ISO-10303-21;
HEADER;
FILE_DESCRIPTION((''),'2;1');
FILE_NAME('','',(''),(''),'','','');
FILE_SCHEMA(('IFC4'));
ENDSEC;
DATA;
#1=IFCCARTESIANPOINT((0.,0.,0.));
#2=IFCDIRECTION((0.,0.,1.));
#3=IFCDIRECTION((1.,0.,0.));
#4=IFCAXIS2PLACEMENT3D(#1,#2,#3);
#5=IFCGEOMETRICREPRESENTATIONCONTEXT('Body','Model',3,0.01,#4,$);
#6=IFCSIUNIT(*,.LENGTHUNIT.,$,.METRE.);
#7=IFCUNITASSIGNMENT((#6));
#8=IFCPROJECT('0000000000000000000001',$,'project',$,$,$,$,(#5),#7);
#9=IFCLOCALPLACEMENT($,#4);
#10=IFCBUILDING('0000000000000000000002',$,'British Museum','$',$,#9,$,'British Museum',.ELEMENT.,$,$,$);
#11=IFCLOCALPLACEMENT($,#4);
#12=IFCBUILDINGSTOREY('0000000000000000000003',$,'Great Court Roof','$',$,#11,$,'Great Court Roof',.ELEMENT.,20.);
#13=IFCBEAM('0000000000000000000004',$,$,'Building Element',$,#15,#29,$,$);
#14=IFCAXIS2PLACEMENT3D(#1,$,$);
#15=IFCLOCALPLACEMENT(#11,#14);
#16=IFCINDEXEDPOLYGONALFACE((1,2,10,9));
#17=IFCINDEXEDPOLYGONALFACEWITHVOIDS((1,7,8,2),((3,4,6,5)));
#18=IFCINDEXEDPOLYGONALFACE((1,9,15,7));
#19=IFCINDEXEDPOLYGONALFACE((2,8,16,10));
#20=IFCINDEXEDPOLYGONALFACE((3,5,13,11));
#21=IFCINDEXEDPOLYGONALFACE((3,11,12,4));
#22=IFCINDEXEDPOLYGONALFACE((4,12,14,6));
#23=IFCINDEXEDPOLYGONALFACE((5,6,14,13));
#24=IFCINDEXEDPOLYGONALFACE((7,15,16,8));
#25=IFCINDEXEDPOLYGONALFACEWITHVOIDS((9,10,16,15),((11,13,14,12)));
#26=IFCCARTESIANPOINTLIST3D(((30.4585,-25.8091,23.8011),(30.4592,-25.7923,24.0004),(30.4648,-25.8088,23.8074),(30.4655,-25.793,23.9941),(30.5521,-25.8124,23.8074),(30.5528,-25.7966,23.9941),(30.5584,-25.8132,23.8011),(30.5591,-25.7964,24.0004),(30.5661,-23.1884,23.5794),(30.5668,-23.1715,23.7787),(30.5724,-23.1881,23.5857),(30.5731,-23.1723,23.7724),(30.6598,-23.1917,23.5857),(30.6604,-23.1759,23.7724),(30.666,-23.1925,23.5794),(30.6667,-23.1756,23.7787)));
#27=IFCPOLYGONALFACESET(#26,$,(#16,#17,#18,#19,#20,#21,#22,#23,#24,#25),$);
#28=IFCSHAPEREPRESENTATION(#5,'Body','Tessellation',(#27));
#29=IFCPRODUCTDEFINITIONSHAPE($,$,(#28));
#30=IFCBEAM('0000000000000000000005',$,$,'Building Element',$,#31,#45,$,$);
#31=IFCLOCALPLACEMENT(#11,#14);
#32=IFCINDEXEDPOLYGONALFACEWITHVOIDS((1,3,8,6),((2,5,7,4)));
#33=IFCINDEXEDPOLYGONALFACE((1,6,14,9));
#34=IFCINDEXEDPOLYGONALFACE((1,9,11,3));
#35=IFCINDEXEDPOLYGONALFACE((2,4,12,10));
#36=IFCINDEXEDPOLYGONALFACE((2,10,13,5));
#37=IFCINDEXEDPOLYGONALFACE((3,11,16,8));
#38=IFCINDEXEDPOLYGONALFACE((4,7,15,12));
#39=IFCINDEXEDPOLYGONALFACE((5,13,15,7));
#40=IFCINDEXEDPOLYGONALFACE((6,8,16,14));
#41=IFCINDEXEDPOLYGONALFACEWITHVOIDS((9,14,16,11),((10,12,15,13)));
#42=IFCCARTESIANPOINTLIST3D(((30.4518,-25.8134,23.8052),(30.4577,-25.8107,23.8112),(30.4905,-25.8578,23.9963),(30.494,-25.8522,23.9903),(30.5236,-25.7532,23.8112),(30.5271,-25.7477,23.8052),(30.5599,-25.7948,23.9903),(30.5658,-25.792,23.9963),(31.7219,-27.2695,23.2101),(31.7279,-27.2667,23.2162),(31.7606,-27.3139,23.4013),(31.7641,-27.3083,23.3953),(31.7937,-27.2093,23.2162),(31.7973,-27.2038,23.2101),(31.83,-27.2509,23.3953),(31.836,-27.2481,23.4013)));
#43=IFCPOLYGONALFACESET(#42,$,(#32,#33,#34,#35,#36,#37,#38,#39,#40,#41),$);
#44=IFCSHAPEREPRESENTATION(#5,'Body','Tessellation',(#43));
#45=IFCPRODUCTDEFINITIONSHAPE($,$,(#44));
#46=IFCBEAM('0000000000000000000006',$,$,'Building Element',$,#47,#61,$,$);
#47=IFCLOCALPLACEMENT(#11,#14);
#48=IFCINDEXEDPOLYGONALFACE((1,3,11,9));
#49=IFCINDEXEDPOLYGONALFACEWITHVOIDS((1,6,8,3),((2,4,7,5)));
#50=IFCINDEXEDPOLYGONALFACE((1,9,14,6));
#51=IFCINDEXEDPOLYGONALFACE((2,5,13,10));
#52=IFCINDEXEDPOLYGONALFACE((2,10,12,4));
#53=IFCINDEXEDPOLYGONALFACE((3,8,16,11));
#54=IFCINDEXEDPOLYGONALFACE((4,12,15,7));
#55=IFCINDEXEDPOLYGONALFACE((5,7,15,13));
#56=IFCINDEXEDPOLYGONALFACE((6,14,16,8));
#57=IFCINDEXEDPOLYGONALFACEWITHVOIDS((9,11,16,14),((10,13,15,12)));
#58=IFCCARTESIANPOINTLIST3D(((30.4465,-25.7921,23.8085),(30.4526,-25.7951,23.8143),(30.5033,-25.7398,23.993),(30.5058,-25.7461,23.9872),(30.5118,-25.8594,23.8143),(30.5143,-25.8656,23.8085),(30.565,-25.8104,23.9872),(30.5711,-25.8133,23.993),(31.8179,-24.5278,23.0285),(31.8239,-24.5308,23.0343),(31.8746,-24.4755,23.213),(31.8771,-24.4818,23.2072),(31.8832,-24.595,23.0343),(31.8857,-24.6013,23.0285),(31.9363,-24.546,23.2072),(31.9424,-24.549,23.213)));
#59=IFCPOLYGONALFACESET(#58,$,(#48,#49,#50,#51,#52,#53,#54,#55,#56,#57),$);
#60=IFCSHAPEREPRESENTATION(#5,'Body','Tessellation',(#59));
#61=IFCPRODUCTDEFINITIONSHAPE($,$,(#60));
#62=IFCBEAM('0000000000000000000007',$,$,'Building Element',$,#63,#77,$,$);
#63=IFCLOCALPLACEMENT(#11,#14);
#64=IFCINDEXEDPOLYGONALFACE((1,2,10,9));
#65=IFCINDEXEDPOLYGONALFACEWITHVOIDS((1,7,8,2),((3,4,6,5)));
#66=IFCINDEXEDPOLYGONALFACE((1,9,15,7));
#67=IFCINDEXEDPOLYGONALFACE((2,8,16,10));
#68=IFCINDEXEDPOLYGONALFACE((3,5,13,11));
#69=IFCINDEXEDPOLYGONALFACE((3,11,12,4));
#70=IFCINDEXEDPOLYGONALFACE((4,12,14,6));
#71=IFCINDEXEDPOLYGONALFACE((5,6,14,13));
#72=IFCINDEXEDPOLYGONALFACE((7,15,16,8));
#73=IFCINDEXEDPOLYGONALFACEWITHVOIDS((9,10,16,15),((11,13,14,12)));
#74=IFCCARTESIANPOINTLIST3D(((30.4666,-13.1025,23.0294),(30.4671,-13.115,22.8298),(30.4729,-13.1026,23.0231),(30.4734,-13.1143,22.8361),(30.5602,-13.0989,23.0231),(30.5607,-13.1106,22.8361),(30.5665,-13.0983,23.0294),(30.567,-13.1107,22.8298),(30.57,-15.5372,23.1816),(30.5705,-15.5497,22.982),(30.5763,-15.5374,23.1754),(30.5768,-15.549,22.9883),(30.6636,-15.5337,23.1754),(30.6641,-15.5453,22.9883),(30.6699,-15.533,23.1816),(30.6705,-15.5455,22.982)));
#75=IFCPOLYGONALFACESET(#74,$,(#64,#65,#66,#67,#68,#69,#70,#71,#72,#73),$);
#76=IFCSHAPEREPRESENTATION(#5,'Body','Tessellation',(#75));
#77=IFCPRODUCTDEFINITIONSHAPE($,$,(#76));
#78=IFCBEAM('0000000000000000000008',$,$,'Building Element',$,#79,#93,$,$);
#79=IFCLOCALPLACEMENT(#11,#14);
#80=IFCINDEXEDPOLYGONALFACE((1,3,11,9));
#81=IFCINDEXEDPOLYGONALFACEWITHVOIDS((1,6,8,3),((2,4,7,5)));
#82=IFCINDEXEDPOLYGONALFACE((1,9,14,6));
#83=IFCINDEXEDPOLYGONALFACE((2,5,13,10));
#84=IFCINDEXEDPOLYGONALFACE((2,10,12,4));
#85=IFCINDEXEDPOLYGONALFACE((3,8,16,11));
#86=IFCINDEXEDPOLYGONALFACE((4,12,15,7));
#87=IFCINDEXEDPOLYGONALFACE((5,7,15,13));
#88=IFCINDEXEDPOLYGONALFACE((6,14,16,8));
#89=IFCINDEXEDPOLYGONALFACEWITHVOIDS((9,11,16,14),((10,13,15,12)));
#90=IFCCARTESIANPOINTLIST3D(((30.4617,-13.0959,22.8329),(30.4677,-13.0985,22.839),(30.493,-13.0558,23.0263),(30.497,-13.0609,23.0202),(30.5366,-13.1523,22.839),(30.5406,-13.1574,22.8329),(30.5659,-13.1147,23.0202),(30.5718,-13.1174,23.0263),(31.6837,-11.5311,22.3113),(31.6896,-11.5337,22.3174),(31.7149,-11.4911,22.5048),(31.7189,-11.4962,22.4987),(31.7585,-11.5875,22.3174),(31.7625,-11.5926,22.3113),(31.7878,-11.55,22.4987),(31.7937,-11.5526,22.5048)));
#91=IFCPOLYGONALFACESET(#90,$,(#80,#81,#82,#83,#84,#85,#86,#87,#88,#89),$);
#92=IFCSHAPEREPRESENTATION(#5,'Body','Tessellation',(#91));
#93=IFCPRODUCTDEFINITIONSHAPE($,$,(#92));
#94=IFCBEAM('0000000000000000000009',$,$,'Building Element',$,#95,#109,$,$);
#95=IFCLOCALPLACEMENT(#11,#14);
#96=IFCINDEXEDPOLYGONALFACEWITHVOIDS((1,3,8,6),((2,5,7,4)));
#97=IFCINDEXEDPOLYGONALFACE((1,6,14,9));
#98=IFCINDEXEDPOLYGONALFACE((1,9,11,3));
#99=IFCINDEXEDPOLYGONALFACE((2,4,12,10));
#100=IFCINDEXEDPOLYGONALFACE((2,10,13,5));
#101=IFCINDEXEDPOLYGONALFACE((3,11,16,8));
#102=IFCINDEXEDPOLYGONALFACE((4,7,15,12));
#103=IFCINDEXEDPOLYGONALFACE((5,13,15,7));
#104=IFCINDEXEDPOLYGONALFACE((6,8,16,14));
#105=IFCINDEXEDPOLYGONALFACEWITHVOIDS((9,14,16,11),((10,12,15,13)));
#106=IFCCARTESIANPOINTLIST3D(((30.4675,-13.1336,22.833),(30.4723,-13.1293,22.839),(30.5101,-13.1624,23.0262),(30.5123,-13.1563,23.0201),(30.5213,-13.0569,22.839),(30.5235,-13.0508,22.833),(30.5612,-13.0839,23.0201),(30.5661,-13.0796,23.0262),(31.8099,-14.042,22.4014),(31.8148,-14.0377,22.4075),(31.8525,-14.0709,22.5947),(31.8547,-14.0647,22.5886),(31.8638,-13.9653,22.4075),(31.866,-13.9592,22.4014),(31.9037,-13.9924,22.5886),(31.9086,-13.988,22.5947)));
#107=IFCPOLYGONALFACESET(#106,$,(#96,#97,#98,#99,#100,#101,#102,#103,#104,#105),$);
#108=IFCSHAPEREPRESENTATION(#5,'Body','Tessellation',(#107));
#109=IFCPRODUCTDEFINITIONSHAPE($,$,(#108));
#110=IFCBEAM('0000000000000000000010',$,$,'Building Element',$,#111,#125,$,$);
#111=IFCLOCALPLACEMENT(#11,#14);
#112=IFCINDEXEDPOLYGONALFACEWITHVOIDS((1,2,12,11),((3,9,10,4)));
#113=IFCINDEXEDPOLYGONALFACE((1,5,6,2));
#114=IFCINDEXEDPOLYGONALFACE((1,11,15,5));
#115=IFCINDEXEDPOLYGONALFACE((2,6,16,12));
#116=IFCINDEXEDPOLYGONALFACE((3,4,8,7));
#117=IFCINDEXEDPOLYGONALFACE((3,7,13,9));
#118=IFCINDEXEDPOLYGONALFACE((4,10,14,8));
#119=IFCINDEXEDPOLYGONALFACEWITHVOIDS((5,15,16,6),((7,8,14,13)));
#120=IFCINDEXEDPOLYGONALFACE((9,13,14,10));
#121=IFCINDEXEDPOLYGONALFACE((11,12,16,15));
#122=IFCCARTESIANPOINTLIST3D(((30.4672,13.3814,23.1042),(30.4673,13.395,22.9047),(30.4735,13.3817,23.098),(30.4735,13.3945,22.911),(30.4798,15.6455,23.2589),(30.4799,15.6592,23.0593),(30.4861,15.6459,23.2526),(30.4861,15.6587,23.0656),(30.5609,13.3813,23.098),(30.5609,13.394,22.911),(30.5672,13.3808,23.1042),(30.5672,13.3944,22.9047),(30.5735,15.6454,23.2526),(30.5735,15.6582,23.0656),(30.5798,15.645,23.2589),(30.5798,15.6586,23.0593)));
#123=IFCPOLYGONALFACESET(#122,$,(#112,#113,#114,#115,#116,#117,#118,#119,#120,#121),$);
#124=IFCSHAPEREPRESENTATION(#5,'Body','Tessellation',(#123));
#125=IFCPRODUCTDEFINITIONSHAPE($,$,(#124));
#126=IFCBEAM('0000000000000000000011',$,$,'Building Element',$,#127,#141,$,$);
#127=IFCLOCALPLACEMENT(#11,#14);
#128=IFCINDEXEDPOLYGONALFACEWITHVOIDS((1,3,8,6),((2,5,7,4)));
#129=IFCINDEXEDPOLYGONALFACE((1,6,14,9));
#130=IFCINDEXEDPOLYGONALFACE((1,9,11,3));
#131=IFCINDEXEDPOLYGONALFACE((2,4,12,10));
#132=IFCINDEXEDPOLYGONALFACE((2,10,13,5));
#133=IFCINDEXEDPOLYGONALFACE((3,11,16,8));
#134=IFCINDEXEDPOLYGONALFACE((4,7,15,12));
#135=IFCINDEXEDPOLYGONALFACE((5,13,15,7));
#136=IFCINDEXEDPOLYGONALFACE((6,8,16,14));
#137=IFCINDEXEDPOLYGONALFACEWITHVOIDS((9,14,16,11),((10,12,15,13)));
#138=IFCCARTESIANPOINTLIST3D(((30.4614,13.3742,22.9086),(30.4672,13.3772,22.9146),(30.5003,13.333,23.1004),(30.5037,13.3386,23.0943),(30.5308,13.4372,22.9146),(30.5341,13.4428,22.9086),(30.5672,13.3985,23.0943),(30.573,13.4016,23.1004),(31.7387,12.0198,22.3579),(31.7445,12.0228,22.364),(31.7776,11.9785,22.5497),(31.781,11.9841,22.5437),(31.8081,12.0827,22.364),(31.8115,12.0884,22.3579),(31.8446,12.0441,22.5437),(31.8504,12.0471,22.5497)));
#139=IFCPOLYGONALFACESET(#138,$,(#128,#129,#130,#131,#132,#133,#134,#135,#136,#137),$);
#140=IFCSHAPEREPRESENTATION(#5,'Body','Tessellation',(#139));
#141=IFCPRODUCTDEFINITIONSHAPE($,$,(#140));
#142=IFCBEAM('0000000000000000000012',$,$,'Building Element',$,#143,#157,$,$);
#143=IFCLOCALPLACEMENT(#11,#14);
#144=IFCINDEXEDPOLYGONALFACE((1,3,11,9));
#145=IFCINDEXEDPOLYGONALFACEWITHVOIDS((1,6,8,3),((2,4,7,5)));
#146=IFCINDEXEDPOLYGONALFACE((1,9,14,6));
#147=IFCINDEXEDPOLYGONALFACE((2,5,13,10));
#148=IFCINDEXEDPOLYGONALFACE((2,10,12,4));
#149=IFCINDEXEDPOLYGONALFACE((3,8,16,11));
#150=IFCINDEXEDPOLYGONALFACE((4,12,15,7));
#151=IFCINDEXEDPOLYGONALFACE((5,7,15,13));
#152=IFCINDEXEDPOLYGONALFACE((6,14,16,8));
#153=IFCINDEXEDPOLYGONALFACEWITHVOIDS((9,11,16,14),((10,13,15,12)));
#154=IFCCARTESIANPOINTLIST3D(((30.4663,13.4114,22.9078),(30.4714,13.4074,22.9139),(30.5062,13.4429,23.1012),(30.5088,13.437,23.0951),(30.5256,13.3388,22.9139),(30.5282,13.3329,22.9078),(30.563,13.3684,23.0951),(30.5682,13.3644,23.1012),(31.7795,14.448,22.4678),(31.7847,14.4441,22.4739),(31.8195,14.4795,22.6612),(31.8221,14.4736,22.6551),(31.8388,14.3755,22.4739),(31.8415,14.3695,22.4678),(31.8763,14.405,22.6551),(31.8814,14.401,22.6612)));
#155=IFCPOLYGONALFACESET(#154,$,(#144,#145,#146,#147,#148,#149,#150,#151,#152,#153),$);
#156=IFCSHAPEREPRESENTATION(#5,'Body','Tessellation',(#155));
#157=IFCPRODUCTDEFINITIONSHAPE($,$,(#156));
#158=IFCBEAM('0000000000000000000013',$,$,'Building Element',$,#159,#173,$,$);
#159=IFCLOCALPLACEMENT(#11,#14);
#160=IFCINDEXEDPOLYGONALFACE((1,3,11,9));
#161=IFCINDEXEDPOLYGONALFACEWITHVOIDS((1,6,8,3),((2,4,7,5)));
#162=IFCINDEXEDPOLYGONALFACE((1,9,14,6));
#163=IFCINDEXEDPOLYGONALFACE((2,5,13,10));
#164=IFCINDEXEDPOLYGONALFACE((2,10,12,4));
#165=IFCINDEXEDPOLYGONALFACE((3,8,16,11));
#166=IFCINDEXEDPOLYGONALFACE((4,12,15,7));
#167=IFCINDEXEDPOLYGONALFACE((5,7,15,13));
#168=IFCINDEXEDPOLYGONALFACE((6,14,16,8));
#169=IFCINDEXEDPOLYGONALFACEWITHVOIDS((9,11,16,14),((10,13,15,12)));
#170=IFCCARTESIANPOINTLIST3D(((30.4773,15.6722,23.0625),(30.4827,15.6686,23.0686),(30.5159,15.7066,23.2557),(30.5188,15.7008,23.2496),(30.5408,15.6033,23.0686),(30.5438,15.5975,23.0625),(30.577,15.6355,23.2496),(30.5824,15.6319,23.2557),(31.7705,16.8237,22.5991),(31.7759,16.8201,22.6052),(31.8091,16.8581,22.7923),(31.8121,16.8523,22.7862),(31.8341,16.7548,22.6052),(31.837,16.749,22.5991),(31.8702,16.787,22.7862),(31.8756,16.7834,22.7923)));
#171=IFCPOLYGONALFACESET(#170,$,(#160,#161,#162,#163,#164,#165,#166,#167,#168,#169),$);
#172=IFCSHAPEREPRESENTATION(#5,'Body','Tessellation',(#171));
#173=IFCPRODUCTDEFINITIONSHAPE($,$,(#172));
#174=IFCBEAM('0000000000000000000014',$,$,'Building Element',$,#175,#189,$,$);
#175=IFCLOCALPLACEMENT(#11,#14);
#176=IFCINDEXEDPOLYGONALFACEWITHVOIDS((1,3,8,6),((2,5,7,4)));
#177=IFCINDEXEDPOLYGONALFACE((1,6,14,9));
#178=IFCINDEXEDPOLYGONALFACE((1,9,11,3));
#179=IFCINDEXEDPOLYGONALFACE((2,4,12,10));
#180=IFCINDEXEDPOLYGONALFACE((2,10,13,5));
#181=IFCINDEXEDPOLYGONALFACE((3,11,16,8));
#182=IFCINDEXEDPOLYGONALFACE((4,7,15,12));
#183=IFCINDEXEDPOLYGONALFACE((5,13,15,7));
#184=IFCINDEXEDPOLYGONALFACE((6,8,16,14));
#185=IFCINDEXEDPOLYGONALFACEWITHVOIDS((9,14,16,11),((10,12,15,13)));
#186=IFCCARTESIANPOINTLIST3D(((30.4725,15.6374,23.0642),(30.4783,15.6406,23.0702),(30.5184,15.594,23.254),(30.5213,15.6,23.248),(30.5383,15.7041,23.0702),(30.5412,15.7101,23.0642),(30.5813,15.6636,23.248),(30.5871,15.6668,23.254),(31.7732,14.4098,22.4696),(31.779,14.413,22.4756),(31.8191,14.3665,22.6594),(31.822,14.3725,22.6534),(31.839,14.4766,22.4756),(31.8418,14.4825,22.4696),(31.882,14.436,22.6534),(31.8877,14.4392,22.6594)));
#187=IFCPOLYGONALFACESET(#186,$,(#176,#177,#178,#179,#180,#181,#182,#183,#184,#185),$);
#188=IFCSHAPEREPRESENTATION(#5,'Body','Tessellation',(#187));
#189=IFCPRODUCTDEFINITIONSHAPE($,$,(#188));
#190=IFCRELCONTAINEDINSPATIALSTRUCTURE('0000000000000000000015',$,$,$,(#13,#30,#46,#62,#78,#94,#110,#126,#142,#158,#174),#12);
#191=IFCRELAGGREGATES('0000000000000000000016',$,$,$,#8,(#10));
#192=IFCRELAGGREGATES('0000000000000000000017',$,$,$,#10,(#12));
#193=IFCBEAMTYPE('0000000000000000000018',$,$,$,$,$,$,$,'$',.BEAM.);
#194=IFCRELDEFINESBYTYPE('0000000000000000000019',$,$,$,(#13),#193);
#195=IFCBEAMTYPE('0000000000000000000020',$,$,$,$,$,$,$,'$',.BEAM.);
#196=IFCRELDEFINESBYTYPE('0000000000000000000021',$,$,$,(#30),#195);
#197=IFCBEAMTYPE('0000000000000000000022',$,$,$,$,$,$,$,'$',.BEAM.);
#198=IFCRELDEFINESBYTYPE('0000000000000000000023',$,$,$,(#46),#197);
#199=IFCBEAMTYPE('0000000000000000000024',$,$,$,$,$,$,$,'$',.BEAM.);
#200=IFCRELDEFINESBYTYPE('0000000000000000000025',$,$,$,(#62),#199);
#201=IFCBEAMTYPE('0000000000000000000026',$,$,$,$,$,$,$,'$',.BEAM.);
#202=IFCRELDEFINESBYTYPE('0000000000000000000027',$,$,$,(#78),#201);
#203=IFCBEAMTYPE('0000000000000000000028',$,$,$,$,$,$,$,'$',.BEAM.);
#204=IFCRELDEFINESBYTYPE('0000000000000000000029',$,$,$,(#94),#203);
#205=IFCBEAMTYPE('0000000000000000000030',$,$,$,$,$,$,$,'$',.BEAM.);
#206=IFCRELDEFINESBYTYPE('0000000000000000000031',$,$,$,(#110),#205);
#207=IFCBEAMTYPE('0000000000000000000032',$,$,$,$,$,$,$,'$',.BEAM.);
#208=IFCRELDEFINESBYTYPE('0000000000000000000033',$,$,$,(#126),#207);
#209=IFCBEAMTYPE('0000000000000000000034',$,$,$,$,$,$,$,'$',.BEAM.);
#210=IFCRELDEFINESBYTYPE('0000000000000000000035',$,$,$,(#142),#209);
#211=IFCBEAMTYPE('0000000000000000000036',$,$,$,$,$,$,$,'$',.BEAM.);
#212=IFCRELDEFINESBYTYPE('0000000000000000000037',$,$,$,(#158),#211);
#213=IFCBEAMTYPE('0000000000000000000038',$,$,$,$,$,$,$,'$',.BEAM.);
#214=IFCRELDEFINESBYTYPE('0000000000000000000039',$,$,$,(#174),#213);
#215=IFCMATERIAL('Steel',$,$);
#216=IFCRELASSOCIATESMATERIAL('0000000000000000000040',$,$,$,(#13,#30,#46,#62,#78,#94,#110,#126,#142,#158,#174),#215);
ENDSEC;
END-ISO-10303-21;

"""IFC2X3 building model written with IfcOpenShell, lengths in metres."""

from ifc_helpers import new_model, si_unit, frame, origin_with_axes, origin_2d, place, context, project, spatial, hollow_rectangle, extrude, material, type_object, element, save


model = new_model("IFC2X3")

# Units and contexts
model_context = context("Model", 3, precision=0.01, world=origin_with_axes(), identifier="Body")
ifc_project = project(units=[si_unit("LENGTHUNIT", "METRE")], contexts=[model_context])

# Building, storey
building_placement = place(None, origin_with_axes())
building = spatial("IfcBuilding", under=ifc_project, at=building_placement, Name="British Museum", Description="$", LongName="British Museum", CompositionType="ELEMENT")
storey_placement = place(None, origin_with_axes())
storey = spatial("IfcBuildingStorey", under=building, at=storey_placement, Name="Great Court Roof", Description="$", LongName="Great Court Roof", CompositionType="ELEMENT", Elevation=20.0)

# Beams
ifc_material = material(Name="Steel")
beam_type_1 = type_object("IfcBeamType", ElementType="$", PredefinedType="BEAM")
beam_1_placement = place(None, origin_with_axes())
element("IfcBeam", 1, at=beam_1_placement, inside=storey, type_object=beam_type_1, material=ifc_material, Description="Building Element", context=model_context, shape_type="SweptSolid", body=[
    extrude(hollow_rectangle(XDim=0.1, YDim=0.2, WallThickness=0.0063, InnerFilletRadius=-0.0063, OuterFilletRadius=0.0, at=origin_2d()), frame((30.5088, -25.8027, 23.9007), z_axis=(0.040885, 0.995608, -0.084218), x_axis=(-0.999158, 0.041031, 0.0)), (0.0, 0.0, 1.0), 2.6323),
])
beam_type_2 = type_object("IfcBeamType", ElementType="$", PredefinedType="BEAM")
beam_2_placement = place(None, origin_with_axes())
element("IfcBeam", 2, at=beam_2_placement, inside=storey, type_object=beam_type_2, material=ifc_material, Description="Building Element", context=model_context, shape_type="SweptSolid", body=[
    extrude(hollow_rectangle(XDim=0.1, YDim=0.2, WallThickness=0.0063, InnerFilletRadius=-0.0063, OuterFilletRadius=0.0, at=origin_2d()), frame((30.5088, -25.8027, 23.9007), z_axis=(0.62824, -0.720206, -0.294308), x_axis=(0.753582, 0.657354, 0.0)), (0.0, 0.0, 1.0), 2.0218),
])
beam_type_3 = type_object("IfcBeamType", ElementType="$", PredefinedType="BEAM")
beam_3_placement = place(None, origin_with_axes())
element("IfcBeam", 3, at=beam_3_placement, inside=storey, type_object=beam_type_3, material=ifc_material, Description="Building Element", context=model_context, shape_type="SweptSolid", body=[
    extrude(hollow_rectangle(XDim=0.1, YDim=0.2, WallThickness=0.0063, InnerFilletRadius=-0.0063, OuterFilletRadius=0.0, at=origin_2d()), frame((30.5088, -25.8027, 23.9007), z_axis=(0.678291, 0.625361, -0.385805), x_axis=(-0.677839, 0.73521, 0.0)), (0.0, 0.0, 1.0), 2.0218),
])
beam_type_4 = type_object("IfcBeamType", ElementType="$", PredefinedType="BEAM")
beam_4_placement = place(None, origin_with_axes())
element("IfcBeam", 4, at=beam_4_placement, inside=storey, type_object=beam_type_4, material=ifc_material, Description="Building Element", context=model_context, shape_type="SweptSolid", body=[
    extrude(hollow_rectangle(XDim=0.1, YDim=0.2, WallThickness=0.0063, InnerFilletRadius=-0.0063, OuterFilletRadius=0.0, at=origin_2d()), frame((30.5168, -13.1066, 22.9296), z_axis=(0.042366, -0.997154, 0.062357), x_axis=(0.999099, 0.042449, 0.0)), (0.0, 0.0, 1.0), 2.4417),
])
beam_type_5 = type_object("IfcBeamType", ElementType="$", PredefinedType="BEAM")
beam_5_placement = place(None, origin_with_axes())
element("IfcBeam", 5, at=beam_5_placement, inside=storey, type_object=beam_type_5, material=ifc_material, Description="Building Element", context=model_context, shape_type="SweptSolid", body=[
    extrude(hollow_rectangle(XDim=0.1, YDim=0.2, WallThickness=0.0063, InnerFilletRadius=-0.0063, OuterFilletRadius=0.0, at=origin_2d()), frame((30.5168, -13.1066, 22.9296), z_axis=(0.595274, 0.762297, -0.25407), x_axis=(-0.78816, 0.61547, 0.0)), (0.0, 0.0, 1.0), 2.0527),
])
beam_type_6 = type_object("IfcBeamType", ElementType="$", PredefinedType="BEAM")
beam_6_placement = place(None, origin_with_axes())
element("IfcBeam", 6, at=beam_6_placement, inside=storey, type_object=beam_type_6, material=ifc_material, Description="Building Element", context=model_context, shape_type="SweptSolid", body=[
    extrude(hollow_rectangle(XDim=0.1, YDim=0.2, WallThickness=0.0063, InnerFilletRadius=-0.0063, OuterFilletRadius=0.0, at=origin_2d()), frame((30.5168, -13.1066, 22.9296), z_axis=(0.800323, -0.541569, -0.257268), x_axis=(0.560433, 0.8282, 0.0)), (0.0, 0.0, 1.0), 1.6774),
])
beam_type_7 = type_object("IfcBeamType", ElementType="$", PredefinedType="BEAM")
beam_7_placement = place(None, origin_with_axes())
element("IfcBeam", 7, at=beam_7_placement, inside=storey, type_object=beam_type_7, material=ifc_material, Description="Building Element", context=model_context, shape_type="SweptSolid", body=[
    extrude(hollow_rectangle(XDim=0.1, YDim=0.2, WallThickness=0.0063, InnerFilletRadius=-0.0063, OuterFilletRadius=0.0, at=origin_2d()), frame((30.5172, 13.3879, 23.0045), z_axis=(0.005552, 0.99766, 0.068138), x_axis=(-0.999985, 0.005565, 0.0)), (0.0, 0.0, 1.0), 2.2695),
])
beam_type_8 = type_object("IfcBeamType", ElementType="$", PredefinedType="BEAM")
beam_8_placement = place(None, origin_with_axes())
element("IfcBeam", 8, at=beam_8_placement, inside=storey, type_object=beam_type_8, material=ifc_material, Description="Building Element", context=model_context, shape_type="SweptSolid", body=[
    extrude(hollow_rectangle(XDim=0.1, YDim=0.2, WallThickness=0.0063, InnerFilletRadius=-0.0063, OuterFilletRadius=0.0, at=origin_2d()), frame((30.5172, 13.3879, 23.0045), z_axis=(0.657917, -0.69764, -0.283626), x_axis=(0.727515, 0.686091, 0.0)), (0.0, 0.0, 1.0), 1.9415),
])
beam_type_9 = type_object("IfcBeamType", ElementType="$", PredefinedType="BEAM")
beam_9_placement = place(None, origin_with_axes())
element("IfcBeam", 9, at=beam_9_placement, inside=storey, type_object=beam_type_9, material=ifc_material, Description="Building Element", context=model_context, shape_type="SweptSolid", body=[
    extrude(hollow_rectangle(XDim=0.1, YDim=0.2, WallThickness=0.0063, InnerFilletRadius=-0.0063, OuterFilletRadius=0.0, at=origin_2d()), frame((30.5172, 13.3879, 23.0045), z_axis=(0.759116, 0.599219, -0.254321), x_axis=(-0.619591, 0.784925, 0.0)), (0.0, 0.0, 1.0), 1.73),
])
beam_type_10 = type_object("IfcBeamType", ElementType="$", PredefinedType="BEAM")
beam_10_placement = place(None, origin_with_axes())
element("IfcBeam", 10, at=beam_10_placement, inside=storey, type_object=beam_type_10, material=ifc_material, Description="Building Element", context=model_context, shape_type="SweptSolid", body=[
    extrude(hollow_rectangle(XDim=0.1, YDim=0.2, WallThickness=0.0063, InnerFilletRadius=-0.0063, OuterFilletRadius=0.0, at=origin_2d()), frame((30.5298, 15.6521, 23.1591), z_axis=(0.721473, 0.64237, -0.258529), x_axis=(-0.664977, 0.746864, 0.0)), (0.0, 0.0, 1.0), 1.7926),
])
beam_type_11 = type_object("IfcBeamType", ElementType="$", PredefinedType="BEAM")
beam_11_placement = place(None, origin_with_axes())
element("IfcBeam", 11, at=beam_11_placement, inside=storey, type_object=beam_type_11, material=ifc_material, Description="Building Element", context=model_context, shape_type="SweptSolid", body=[
    extrude(hollow_rectangle(XDim=0.1, YDim=0.2, WallThickness=0.0063, InnerFilletRadius=-0.0063, OuterFilletRadius=0.0, at=origin_2d()), frame((30.5298, 15.6521, 23.1591), z_axis=(0.690113, -0.651313, -0.315491), x_axis=(0.686367, 0.727255, 0.0)), (0.0, 0.0, 1.0), 1.8847),
])

save(model, "model.ifc")
